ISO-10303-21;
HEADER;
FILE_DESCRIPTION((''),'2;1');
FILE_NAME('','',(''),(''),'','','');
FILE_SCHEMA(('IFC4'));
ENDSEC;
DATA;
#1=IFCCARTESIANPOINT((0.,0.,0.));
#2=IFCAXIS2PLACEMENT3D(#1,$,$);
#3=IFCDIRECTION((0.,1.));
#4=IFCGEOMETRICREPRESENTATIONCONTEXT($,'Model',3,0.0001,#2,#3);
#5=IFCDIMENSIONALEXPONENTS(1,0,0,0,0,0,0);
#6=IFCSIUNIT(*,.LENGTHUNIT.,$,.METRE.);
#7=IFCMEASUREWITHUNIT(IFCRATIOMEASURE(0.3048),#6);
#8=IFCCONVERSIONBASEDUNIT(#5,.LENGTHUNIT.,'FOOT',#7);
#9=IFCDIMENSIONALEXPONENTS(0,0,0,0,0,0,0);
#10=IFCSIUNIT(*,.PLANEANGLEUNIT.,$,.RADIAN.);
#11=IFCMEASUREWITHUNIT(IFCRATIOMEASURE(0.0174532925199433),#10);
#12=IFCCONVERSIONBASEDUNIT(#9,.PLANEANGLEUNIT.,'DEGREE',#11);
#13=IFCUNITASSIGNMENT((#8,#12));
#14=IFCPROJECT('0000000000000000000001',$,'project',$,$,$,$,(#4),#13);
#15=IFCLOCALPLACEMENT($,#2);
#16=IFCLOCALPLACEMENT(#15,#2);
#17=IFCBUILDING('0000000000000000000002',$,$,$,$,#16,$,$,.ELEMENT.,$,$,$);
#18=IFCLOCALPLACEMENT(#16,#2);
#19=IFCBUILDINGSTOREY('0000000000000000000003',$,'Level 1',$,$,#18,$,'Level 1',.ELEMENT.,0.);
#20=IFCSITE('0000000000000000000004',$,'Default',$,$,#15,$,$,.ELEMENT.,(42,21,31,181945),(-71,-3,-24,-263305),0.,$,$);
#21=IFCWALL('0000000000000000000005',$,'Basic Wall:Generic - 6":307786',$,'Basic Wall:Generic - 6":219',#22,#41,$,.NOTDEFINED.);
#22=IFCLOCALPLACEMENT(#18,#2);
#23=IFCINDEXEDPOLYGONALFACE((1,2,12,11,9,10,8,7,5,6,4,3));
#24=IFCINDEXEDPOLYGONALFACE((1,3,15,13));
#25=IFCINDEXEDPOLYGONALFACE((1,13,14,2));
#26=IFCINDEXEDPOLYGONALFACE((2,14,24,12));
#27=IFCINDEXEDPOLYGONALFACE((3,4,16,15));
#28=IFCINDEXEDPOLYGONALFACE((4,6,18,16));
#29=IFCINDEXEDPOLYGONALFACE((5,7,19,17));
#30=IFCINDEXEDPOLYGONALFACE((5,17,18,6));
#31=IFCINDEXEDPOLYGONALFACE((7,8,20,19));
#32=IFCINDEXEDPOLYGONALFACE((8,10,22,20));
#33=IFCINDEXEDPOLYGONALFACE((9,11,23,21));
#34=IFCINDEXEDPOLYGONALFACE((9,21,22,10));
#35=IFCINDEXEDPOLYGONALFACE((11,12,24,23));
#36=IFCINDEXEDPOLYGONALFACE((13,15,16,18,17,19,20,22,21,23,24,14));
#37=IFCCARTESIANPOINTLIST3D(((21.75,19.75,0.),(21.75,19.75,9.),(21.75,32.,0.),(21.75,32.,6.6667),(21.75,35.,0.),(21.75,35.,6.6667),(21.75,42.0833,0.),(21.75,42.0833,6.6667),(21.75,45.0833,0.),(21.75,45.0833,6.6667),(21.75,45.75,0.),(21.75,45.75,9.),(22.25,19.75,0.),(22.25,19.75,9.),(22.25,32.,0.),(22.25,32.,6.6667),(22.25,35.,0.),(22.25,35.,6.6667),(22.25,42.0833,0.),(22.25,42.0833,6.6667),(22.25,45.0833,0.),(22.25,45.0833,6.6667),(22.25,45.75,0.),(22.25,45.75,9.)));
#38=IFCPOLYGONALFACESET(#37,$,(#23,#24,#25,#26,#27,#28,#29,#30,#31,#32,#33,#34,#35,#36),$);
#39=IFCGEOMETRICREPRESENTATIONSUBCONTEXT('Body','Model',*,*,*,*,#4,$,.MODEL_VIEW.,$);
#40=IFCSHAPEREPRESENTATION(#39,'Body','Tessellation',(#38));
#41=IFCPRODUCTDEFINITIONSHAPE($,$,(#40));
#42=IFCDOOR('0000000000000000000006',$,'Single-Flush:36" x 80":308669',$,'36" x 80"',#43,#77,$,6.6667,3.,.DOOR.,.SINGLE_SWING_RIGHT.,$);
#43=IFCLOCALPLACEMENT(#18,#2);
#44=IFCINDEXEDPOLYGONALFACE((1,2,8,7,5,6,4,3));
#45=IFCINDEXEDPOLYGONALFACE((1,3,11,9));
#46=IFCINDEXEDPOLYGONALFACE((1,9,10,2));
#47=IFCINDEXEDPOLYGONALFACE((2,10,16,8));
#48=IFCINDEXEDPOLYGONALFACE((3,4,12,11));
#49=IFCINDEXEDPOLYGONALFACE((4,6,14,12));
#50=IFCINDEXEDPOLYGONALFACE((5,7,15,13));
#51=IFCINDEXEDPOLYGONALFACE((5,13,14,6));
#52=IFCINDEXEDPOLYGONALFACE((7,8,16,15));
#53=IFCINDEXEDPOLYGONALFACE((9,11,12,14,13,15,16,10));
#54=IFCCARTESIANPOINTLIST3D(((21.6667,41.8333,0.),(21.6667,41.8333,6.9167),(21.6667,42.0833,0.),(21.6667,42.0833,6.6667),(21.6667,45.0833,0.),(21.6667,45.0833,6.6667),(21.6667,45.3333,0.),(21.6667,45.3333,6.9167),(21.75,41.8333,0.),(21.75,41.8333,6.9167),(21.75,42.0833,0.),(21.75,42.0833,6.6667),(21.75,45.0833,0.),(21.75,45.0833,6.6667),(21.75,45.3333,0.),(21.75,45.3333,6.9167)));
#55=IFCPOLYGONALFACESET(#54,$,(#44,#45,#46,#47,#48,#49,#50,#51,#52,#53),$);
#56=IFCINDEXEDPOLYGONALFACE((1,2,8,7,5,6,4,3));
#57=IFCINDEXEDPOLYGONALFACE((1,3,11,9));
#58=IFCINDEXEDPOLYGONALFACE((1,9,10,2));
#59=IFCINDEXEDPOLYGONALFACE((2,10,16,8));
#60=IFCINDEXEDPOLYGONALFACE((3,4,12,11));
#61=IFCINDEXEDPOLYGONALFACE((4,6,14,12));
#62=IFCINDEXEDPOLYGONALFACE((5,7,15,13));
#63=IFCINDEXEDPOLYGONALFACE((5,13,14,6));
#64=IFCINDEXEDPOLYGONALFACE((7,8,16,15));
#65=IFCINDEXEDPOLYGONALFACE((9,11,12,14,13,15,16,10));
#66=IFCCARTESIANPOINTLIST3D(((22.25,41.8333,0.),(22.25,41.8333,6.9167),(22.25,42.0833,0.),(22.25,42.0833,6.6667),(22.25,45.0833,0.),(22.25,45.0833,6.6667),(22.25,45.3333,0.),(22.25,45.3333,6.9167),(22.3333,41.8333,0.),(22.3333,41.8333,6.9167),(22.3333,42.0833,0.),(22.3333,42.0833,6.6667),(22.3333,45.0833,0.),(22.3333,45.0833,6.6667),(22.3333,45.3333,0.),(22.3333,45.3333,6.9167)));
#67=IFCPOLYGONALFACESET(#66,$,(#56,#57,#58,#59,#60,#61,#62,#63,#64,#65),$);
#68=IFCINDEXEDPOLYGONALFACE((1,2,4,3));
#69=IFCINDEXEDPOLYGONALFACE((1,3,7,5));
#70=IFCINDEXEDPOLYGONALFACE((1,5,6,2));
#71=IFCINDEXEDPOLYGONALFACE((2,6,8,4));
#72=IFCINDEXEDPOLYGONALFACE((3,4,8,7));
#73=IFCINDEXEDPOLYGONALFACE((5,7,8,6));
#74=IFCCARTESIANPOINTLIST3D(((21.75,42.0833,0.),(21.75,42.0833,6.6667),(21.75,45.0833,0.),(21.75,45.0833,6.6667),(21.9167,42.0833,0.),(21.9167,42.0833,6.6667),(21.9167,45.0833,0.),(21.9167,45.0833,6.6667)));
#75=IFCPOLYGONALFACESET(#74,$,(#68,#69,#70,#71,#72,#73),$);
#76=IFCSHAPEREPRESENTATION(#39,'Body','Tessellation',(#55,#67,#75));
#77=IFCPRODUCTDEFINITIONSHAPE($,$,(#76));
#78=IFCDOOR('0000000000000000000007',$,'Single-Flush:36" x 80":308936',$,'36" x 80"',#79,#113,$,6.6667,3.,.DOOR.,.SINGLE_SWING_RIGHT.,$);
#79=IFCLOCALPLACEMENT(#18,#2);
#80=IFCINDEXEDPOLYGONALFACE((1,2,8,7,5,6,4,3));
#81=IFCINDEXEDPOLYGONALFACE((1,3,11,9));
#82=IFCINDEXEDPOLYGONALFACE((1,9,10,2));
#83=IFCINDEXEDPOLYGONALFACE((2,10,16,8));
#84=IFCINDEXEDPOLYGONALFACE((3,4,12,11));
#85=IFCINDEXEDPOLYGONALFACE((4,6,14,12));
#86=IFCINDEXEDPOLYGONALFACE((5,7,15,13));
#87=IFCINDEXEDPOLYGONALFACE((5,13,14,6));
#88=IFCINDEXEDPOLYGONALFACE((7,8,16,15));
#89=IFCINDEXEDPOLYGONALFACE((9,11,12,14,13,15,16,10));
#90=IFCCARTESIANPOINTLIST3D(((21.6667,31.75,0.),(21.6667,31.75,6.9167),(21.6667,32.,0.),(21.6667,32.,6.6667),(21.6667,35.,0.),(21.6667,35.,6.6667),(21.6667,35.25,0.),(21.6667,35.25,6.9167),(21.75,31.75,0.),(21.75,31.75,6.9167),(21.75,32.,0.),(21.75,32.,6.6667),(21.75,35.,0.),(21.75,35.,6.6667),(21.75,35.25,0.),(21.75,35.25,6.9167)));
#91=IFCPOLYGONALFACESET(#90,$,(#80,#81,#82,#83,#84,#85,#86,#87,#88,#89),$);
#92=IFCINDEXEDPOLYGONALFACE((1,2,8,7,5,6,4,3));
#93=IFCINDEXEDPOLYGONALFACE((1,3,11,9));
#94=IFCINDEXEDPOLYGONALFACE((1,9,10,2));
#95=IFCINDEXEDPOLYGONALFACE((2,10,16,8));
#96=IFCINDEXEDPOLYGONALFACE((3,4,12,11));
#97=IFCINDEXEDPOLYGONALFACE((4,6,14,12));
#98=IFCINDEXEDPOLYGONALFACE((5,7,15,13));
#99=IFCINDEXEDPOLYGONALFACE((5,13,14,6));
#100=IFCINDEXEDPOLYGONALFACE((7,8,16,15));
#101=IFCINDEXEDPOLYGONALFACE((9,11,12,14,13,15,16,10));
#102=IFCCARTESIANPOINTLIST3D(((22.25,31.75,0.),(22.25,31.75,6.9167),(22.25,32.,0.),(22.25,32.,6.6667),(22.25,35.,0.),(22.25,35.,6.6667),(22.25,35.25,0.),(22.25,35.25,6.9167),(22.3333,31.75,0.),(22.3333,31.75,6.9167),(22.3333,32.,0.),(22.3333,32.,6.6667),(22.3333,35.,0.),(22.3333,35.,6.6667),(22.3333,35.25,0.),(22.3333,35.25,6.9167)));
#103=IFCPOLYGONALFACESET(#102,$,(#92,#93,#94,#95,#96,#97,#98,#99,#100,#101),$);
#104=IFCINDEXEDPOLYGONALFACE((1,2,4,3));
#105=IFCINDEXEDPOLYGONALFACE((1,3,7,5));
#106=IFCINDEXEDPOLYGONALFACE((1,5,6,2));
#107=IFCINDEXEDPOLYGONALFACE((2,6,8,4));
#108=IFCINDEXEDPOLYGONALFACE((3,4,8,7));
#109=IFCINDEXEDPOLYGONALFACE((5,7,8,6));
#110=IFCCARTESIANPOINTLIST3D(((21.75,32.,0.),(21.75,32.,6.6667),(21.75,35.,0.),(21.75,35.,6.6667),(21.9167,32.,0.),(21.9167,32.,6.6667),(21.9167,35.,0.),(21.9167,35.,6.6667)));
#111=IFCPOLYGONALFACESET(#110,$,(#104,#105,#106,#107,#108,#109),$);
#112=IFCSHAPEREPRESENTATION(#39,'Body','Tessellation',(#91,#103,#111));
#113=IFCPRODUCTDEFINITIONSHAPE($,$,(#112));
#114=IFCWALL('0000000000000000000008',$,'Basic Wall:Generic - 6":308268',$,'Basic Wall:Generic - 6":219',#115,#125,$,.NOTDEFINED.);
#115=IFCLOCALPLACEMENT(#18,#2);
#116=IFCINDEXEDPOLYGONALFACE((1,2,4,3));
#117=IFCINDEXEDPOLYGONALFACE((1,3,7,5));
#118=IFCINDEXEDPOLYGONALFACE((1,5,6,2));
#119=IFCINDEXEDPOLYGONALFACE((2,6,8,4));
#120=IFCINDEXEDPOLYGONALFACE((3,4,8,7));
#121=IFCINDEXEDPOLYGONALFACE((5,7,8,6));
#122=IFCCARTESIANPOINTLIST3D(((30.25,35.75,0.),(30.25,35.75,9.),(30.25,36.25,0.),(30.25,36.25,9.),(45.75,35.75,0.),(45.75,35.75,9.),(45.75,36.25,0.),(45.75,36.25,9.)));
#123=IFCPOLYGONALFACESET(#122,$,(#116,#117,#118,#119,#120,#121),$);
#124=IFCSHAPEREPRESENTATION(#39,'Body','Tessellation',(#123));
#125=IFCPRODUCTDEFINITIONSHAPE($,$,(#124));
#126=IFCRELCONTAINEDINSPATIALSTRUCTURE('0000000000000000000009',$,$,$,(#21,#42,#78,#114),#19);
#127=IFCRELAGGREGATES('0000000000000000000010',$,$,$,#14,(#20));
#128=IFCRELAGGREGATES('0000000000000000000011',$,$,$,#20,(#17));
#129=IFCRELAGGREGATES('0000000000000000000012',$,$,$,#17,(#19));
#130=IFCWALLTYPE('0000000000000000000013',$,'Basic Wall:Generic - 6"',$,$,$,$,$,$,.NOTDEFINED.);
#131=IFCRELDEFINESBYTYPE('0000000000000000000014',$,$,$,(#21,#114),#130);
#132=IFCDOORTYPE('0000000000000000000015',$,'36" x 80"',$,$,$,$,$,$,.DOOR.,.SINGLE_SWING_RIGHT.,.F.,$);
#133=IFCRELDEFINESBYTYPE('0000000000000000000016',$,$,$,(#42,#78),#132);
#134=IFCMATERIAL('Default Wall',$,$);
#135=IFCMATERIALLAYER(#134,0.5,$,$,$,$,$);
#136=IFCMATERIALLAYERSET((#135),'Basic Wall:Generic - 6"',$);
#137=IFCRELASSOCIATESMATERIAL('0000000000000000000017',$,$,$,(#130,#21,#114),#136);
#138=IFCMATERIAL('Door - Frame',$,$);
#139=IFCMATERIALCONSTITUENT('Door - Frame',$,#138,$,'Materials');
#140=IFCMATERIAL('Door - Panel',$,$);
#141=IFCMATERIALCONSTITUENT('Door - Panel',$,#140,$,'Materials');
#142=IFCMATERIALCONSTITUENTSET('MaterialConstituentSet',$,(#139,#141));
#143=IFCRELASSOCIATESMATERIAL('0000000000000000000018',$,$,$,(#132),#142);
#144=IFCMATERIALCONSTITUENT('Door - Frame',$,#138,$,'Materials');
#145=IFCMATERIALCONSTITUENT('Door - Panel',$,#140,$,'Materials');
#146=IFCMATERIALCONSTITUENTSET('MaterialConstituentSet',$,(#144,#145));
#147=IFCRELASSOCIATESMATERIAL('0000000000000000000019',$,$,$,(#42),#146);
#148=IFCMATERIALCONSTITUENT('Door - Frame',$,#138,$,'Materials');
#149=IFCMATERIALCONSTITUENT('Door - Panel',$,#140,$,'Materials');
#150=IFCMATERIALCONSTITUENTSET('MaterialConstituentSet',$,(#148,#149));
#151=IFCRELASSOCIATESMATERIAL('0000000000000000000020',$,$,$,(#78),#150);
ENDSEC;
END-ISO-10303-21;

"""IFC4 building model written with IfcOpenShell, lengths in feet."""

from ifc_helpers import new_model, entity, si_unit, converted_unit, direction, frame, frame_2d, origin, origin_2d_with_axis, place, context, subcontext, project, spatial, polyline, rectangle, outline, extrude, clip, bounded_halfspace, source, transform, mapped, material, layer, layer_set, layer_usage, constituent, constituent_set, type_object, type_shapes, element, fill, save


model = new_model("IFC4")

# Units and contexts
model_context = context("Model", 3, precision=0.0001, world=origin(), true_north=direction((0.0, 1.0)))
body_context = subcontext(model_context, "Body", "Model", "MODEL_VIEW")
ifc_project = project(units=[converted_unit("LENGTHUNIT", "FOOT", entity("IfcRatioMeasure", 0.3048), si_unit("LENGTHUNIT", "METRE"), dimensions=[1, 0, 0, 0, 0, 0, 0]), converted_unit("PLANEANGLEUNIT", "DEGREE", entity("IfcRatioMeasure", 0.0174532925199433), si_unit("PLANEANGLEUNIT", "RADIAN"), dimensions=[0, 0, 0, 0, 0, 0, 0])], contexts=[model_context])

# Site, building, storey
site_placement = place(None, origin())
site = spatial("IfcSite", under=ifc_project, at=site_placement, Name="Default", CompositionType="ELEMENT", RefLatitude=(42, 21, 31, 181945), RefLongitude=(-71, -3, -24, -263305), RefElevation=0.0)
building_placement = place(site_placement, origin())
building = spatial("IfcBuilding", under=site, at=building_placement, CompositionType="ELEMENT")
storey_placement = place(building_placement, origin())
storey = spatial("IfcBuildingStorey", under=building, at=storey_placement, Name="Level 1", LongName="Level 1", CompositionType="ELEMENT", Elevation=0.0)

# Shared definitions
ifc_material_1 = material(Name="Default Wall")
ifc_layer = layer(ifc_material_1, 0.5)
ifc_layer_set = layer_set([ifc_layer], Name="Basic Wall:Generic - 6\"")
wall_type = type_object("IfcWallType", Name="Basic Wall:Generic - 6\"", PredefinedType="NOTDEFINED", material=ifc_layer_set)
ifc_material_2 = material(Name="Door - Frame")
ifc_material_3 = material(Name="Door - Panel")
ifc_constituent_1 = constituent(ifc_material_2, Name="Door - Frame", Category="Materials")
ifc_constituent_2 = constituent(ifc_material_3, Name="Door - Panel", Category="Materials")
ifc_constituent_set_1 = constituent_set(constituents=[ifc_constituent_1, ifc_constituent_2], Name="MaterialConstituentSet")
door_type_1 = type_object("IfcDoorType", Name="36\" x 80\"", OperationType="SINGLE_SWING_RIGHT", ParameterTakesPrecedence=False, PredefinedType="DOOR", material=ifc_constituent_set_1)
shared_shape_1 = source(origin(), body_context, "Body", "SweptSolid", [
    extrude(outline(polyline([(-1.75, -3.5208), (1.75, -3.5208), (1.75, 3.3958), (1.5, 3.3958), (1.5, -3.2708), (-1.5, -3.2708), (-1.5, 3.3958), (-1.75, 3.3958), (-1.75, -3.5208)])), frame((1.5, 0.5, 3.3958), z_axis=(0.0, 1.0, 0.0), x_axis=(1.0, 0.0, 0.0)), (0.0, 0.0, 1.0), 0.0833),
    extrude(outline(polyline([(-3.5208, -1.75), (3.3958, -1.75), (3.3958, -1.5), (-3.2708, -1.5), (-3.2708, 1.5), (3.3958, 1.5), (3.3958, 1.75), (-3.5208, 1.75), (-3.5208, -1.75)])), frame((1.5, -0.0833, 3.3958), z_axis=(0.0, 1.0, 0.0), x_axis=(0.0, 0.0, -1.0)), (0.0, 0.0, 1.0), 0.0833),
    extrude(rectangle(XDim=0.1667, YDim=3.0, at=origin_2d_with_axis()), frame((1.5, 0.4167, 0.0), z_axis=(0.0, 0.0, 1.0), x_axis=(0.0, 1.0, 0.0)), (0.0, 0.0, 1.0), 6.6667),
])
type_shapes(door_type_1, [shared_shape_1])

# Wall, openings, doors
ifc_layer_usage_1 = layer_usage(ifc_layer_set, "AXIS2", "NEGATIVE", 0.25)
wall_1_placement = place(storey_placement, frame((22.0, 45.75, 0.0), z_axis=(0.0, 0.0, 1.0), x_axis=(0.0, -1.0, 0.0)))
wall_1 = element("IfcWall", 1, at=wall_1_placement, inside=storey, type_object=wall_type, material=ifc_layer_usage_1, Name="Basic Wall:Generic - 6\":307786", ObjectType="Basic Wall:Generic - 6\":219", PredefinedType="NOTDEFINED", context=body_context, shape_type="Clipping", body=[
    clip(clip(clip(extrude(rectangle(XDim=26.0, YDim=0.5, at=frame_2d((13.0, 0.0), x_axis=(-1.0, 0.0))), origin(), (0.0, 0.0, 1.0), 9.0), bounded_halfspace(frame((10.0, -0.25, 9.0), z_axis=(0.0, 0.0, -1.0), x_axis=(0.0, -1.0, 0.0)), True, frame((10.0, -0.25, 9.0)), polyline([(0.0, 0.0), (0.0, 0.5), (-10.0, 0.5), (-10.0, 0.0), (-0.5, 0.0), (0.0, 0.0)]))), bounded_halfspace(frame((10.0, -0.25, 9.0), z_axis=(0.0, 0.0, -1.0), x_axis=(-1.0, 0.0, 0.0)), True, frame((10.0, -0.25, 9.0)), polyline([(0.0, 0.0), (15.5, 0.0), (15.5, 0.5), (0.0, 0.5), (0.0, 0.0)]))), bounded_halfspace(frame((25.5, -0.25, 9.0), z_axis=(0.0, 0.0, -1.0), x_axis=(1.0, 0.0, 0.0)), True, frame((25.5, -0.25, 9.0)), polyline([(0.0, 0.0), (0.5, 0.0), (0.5, 0.5), (0.0, 0.5), (0.0, 0.0)]))),
])
opening_1_placement = place(wall_1_placement, frame((3.6667, 0.25, 0.0)))
opening_1 = element("IfcOpeningElement", 2, at=opening_1_placement, cuts=wall_1, ObjectType="Opening", PredefinedType="OPENING", context=body_context, shape_type="SweptSolid", body=[
    extrude(rectangle(XDim=3.0, YDim=6.6667, at=frame_2d((3.3333, 1.5), x_axis=(0.0, 1.0))), frame((0.0, 0.0, 0.0), z_axis=(0.0, -1.0, 0.0), x_axis=(0.0, 0.0, 1.0)), (0.0, 0.0, 1.0), 0.5),
])
opening_2_placement = place(wall_1_placement, frame((13.75, 0.25, 0.0)))
opening_2 = element("IfcOpeningElement", 3, at=opening_2_placement, cuts=wall_1, ObjectType="Opening", PredefinedType="OPENING", context=body_context, shape_type="SweptSolid", body=[
    extrude(rectangle(XDim=3.0, YDim=6.6667, at=frame_2d((3.3333, 1.5), x_axis=(0.0, 1.0))), frame((0.0, 0.0, 0.0), z_axis=(0.0, -1.0, 0.0), x_axis=(0.0, 0.0, 1.0)), (0.0, 0.0, 1.0), 0.5),
])
ifc_constituent_3 = constituent(ifc_material_2, Name="Door - Frame", Category="Materials")
ifc_constituent_4 = constituent(ifc_material_3, Name="Door - Panel", Category="Materials")
ifc_constituent_set_2 = constituent_set(constituents=[ifc_constituent_3, ifc_constituent_4], Name="MaterialConstituentSet")
door_1_placement = place(opening_1_placement, frame((0.0, 0.0, 0.0), z_axis=(0.0, 0.0, 1.0), x_axis=(-1.0, 0.0, 0.0)))
door_1 = element("IfcDoor", 4, at=door_1_placement, inside=storey, type_object=door_type_1, material=ifc_constituent_set_2, Name="Single-Flush:36\" x 80\":308669", ObjectType="36\" x 80\"", OperationType="SINGLE_SWING_RIGHT", OverallHeight=6.6667, OverallWidth=3.0, PredefinedType="DOOR", context=body_context, shape_type="MappedRepresentation", body=[
    mapped(shared_shape_1, transform((0.0, 0.0, 0.0), scale=1.0)),
])
fill(opening_1, door_1)
ifc_constituent_5 = constituent(ifc_material_2, Name="Door - Frame", Category="Materials")
ifc_constituent_6 = constituent(ifc_material_3, Name="Door - Panel", Category="Materials")
ifc_constituent_set_3 = constituent_set(constituents=[ifc_constituent_5, ifc_constituent_6], Name="MaterialConstituentSet")
door_2_placement = place(opening_2_placement, frame((0.0, 0.0, 0.0), z_axis=(0.0, 0.0, 1.0), x_axis=(-1.0, 0.0, 0.0)))
door_2 = element("IfcDoor", 5, at=door_2_placement, inside=storey, type_object=door_type_1, material=ifc_constituent_set_3, Name="Single-Flush:36\" x 80\":308936", ObjectType="36\" x 80\"", OperationType="SINGLE_SWING_RIGHT", OverallHeight=6.6667, OverallWidth=3.0, PredefinedType="DOOR", context=body_context, shape_type="MappedRepresentation", body=[
    mapped(shared_shape_1, transform((0.0, 0.0, 0.0), scale=1.0)),
])
fill(opening_2, door_2)

# Wall
ifc_layer_usage_2 = layer_usage(ifc_layer_set, "AXIS2", "NEGATIVE", 0.25)
wall_2_placement = place(storey_placement, frame((30.25, 36.0, 0.0)))
element("IfcWall", 6, at=wall_2_placement, inside=storey, type_object=wall_type, material=ifc_layer_usage_2, Name="Basic Wall:Generic - 6\":308268", ObjectType="Basic Wall:Generic - 6\":219", PredefinedType="NOTDEFINED", context=body_context, shape_type="Clipping", body=[
    clip(extrude(rectangle(XDim=15.5, YDim=0.5, at=frame_2d((7.75, 0.0), x_axis=(-1.0, 0.0))), origin(), (0.0, 0.0, 1.0), 9.0), bounded_halfspace(frame((0.0, -0.25, 9.0), z_axis=(0.0, 0.0, -1.0), x_axis=(1.0, 0.0, 0.0)), True, frame((0.0, -0.25, 9.0)), polyline([(0.0, 0.0), (15.5, 0.0), (15.5, 0.5), (0.0, 0.5), (0.0, 0.0)]))),
])

save(model, "model.ifc")
